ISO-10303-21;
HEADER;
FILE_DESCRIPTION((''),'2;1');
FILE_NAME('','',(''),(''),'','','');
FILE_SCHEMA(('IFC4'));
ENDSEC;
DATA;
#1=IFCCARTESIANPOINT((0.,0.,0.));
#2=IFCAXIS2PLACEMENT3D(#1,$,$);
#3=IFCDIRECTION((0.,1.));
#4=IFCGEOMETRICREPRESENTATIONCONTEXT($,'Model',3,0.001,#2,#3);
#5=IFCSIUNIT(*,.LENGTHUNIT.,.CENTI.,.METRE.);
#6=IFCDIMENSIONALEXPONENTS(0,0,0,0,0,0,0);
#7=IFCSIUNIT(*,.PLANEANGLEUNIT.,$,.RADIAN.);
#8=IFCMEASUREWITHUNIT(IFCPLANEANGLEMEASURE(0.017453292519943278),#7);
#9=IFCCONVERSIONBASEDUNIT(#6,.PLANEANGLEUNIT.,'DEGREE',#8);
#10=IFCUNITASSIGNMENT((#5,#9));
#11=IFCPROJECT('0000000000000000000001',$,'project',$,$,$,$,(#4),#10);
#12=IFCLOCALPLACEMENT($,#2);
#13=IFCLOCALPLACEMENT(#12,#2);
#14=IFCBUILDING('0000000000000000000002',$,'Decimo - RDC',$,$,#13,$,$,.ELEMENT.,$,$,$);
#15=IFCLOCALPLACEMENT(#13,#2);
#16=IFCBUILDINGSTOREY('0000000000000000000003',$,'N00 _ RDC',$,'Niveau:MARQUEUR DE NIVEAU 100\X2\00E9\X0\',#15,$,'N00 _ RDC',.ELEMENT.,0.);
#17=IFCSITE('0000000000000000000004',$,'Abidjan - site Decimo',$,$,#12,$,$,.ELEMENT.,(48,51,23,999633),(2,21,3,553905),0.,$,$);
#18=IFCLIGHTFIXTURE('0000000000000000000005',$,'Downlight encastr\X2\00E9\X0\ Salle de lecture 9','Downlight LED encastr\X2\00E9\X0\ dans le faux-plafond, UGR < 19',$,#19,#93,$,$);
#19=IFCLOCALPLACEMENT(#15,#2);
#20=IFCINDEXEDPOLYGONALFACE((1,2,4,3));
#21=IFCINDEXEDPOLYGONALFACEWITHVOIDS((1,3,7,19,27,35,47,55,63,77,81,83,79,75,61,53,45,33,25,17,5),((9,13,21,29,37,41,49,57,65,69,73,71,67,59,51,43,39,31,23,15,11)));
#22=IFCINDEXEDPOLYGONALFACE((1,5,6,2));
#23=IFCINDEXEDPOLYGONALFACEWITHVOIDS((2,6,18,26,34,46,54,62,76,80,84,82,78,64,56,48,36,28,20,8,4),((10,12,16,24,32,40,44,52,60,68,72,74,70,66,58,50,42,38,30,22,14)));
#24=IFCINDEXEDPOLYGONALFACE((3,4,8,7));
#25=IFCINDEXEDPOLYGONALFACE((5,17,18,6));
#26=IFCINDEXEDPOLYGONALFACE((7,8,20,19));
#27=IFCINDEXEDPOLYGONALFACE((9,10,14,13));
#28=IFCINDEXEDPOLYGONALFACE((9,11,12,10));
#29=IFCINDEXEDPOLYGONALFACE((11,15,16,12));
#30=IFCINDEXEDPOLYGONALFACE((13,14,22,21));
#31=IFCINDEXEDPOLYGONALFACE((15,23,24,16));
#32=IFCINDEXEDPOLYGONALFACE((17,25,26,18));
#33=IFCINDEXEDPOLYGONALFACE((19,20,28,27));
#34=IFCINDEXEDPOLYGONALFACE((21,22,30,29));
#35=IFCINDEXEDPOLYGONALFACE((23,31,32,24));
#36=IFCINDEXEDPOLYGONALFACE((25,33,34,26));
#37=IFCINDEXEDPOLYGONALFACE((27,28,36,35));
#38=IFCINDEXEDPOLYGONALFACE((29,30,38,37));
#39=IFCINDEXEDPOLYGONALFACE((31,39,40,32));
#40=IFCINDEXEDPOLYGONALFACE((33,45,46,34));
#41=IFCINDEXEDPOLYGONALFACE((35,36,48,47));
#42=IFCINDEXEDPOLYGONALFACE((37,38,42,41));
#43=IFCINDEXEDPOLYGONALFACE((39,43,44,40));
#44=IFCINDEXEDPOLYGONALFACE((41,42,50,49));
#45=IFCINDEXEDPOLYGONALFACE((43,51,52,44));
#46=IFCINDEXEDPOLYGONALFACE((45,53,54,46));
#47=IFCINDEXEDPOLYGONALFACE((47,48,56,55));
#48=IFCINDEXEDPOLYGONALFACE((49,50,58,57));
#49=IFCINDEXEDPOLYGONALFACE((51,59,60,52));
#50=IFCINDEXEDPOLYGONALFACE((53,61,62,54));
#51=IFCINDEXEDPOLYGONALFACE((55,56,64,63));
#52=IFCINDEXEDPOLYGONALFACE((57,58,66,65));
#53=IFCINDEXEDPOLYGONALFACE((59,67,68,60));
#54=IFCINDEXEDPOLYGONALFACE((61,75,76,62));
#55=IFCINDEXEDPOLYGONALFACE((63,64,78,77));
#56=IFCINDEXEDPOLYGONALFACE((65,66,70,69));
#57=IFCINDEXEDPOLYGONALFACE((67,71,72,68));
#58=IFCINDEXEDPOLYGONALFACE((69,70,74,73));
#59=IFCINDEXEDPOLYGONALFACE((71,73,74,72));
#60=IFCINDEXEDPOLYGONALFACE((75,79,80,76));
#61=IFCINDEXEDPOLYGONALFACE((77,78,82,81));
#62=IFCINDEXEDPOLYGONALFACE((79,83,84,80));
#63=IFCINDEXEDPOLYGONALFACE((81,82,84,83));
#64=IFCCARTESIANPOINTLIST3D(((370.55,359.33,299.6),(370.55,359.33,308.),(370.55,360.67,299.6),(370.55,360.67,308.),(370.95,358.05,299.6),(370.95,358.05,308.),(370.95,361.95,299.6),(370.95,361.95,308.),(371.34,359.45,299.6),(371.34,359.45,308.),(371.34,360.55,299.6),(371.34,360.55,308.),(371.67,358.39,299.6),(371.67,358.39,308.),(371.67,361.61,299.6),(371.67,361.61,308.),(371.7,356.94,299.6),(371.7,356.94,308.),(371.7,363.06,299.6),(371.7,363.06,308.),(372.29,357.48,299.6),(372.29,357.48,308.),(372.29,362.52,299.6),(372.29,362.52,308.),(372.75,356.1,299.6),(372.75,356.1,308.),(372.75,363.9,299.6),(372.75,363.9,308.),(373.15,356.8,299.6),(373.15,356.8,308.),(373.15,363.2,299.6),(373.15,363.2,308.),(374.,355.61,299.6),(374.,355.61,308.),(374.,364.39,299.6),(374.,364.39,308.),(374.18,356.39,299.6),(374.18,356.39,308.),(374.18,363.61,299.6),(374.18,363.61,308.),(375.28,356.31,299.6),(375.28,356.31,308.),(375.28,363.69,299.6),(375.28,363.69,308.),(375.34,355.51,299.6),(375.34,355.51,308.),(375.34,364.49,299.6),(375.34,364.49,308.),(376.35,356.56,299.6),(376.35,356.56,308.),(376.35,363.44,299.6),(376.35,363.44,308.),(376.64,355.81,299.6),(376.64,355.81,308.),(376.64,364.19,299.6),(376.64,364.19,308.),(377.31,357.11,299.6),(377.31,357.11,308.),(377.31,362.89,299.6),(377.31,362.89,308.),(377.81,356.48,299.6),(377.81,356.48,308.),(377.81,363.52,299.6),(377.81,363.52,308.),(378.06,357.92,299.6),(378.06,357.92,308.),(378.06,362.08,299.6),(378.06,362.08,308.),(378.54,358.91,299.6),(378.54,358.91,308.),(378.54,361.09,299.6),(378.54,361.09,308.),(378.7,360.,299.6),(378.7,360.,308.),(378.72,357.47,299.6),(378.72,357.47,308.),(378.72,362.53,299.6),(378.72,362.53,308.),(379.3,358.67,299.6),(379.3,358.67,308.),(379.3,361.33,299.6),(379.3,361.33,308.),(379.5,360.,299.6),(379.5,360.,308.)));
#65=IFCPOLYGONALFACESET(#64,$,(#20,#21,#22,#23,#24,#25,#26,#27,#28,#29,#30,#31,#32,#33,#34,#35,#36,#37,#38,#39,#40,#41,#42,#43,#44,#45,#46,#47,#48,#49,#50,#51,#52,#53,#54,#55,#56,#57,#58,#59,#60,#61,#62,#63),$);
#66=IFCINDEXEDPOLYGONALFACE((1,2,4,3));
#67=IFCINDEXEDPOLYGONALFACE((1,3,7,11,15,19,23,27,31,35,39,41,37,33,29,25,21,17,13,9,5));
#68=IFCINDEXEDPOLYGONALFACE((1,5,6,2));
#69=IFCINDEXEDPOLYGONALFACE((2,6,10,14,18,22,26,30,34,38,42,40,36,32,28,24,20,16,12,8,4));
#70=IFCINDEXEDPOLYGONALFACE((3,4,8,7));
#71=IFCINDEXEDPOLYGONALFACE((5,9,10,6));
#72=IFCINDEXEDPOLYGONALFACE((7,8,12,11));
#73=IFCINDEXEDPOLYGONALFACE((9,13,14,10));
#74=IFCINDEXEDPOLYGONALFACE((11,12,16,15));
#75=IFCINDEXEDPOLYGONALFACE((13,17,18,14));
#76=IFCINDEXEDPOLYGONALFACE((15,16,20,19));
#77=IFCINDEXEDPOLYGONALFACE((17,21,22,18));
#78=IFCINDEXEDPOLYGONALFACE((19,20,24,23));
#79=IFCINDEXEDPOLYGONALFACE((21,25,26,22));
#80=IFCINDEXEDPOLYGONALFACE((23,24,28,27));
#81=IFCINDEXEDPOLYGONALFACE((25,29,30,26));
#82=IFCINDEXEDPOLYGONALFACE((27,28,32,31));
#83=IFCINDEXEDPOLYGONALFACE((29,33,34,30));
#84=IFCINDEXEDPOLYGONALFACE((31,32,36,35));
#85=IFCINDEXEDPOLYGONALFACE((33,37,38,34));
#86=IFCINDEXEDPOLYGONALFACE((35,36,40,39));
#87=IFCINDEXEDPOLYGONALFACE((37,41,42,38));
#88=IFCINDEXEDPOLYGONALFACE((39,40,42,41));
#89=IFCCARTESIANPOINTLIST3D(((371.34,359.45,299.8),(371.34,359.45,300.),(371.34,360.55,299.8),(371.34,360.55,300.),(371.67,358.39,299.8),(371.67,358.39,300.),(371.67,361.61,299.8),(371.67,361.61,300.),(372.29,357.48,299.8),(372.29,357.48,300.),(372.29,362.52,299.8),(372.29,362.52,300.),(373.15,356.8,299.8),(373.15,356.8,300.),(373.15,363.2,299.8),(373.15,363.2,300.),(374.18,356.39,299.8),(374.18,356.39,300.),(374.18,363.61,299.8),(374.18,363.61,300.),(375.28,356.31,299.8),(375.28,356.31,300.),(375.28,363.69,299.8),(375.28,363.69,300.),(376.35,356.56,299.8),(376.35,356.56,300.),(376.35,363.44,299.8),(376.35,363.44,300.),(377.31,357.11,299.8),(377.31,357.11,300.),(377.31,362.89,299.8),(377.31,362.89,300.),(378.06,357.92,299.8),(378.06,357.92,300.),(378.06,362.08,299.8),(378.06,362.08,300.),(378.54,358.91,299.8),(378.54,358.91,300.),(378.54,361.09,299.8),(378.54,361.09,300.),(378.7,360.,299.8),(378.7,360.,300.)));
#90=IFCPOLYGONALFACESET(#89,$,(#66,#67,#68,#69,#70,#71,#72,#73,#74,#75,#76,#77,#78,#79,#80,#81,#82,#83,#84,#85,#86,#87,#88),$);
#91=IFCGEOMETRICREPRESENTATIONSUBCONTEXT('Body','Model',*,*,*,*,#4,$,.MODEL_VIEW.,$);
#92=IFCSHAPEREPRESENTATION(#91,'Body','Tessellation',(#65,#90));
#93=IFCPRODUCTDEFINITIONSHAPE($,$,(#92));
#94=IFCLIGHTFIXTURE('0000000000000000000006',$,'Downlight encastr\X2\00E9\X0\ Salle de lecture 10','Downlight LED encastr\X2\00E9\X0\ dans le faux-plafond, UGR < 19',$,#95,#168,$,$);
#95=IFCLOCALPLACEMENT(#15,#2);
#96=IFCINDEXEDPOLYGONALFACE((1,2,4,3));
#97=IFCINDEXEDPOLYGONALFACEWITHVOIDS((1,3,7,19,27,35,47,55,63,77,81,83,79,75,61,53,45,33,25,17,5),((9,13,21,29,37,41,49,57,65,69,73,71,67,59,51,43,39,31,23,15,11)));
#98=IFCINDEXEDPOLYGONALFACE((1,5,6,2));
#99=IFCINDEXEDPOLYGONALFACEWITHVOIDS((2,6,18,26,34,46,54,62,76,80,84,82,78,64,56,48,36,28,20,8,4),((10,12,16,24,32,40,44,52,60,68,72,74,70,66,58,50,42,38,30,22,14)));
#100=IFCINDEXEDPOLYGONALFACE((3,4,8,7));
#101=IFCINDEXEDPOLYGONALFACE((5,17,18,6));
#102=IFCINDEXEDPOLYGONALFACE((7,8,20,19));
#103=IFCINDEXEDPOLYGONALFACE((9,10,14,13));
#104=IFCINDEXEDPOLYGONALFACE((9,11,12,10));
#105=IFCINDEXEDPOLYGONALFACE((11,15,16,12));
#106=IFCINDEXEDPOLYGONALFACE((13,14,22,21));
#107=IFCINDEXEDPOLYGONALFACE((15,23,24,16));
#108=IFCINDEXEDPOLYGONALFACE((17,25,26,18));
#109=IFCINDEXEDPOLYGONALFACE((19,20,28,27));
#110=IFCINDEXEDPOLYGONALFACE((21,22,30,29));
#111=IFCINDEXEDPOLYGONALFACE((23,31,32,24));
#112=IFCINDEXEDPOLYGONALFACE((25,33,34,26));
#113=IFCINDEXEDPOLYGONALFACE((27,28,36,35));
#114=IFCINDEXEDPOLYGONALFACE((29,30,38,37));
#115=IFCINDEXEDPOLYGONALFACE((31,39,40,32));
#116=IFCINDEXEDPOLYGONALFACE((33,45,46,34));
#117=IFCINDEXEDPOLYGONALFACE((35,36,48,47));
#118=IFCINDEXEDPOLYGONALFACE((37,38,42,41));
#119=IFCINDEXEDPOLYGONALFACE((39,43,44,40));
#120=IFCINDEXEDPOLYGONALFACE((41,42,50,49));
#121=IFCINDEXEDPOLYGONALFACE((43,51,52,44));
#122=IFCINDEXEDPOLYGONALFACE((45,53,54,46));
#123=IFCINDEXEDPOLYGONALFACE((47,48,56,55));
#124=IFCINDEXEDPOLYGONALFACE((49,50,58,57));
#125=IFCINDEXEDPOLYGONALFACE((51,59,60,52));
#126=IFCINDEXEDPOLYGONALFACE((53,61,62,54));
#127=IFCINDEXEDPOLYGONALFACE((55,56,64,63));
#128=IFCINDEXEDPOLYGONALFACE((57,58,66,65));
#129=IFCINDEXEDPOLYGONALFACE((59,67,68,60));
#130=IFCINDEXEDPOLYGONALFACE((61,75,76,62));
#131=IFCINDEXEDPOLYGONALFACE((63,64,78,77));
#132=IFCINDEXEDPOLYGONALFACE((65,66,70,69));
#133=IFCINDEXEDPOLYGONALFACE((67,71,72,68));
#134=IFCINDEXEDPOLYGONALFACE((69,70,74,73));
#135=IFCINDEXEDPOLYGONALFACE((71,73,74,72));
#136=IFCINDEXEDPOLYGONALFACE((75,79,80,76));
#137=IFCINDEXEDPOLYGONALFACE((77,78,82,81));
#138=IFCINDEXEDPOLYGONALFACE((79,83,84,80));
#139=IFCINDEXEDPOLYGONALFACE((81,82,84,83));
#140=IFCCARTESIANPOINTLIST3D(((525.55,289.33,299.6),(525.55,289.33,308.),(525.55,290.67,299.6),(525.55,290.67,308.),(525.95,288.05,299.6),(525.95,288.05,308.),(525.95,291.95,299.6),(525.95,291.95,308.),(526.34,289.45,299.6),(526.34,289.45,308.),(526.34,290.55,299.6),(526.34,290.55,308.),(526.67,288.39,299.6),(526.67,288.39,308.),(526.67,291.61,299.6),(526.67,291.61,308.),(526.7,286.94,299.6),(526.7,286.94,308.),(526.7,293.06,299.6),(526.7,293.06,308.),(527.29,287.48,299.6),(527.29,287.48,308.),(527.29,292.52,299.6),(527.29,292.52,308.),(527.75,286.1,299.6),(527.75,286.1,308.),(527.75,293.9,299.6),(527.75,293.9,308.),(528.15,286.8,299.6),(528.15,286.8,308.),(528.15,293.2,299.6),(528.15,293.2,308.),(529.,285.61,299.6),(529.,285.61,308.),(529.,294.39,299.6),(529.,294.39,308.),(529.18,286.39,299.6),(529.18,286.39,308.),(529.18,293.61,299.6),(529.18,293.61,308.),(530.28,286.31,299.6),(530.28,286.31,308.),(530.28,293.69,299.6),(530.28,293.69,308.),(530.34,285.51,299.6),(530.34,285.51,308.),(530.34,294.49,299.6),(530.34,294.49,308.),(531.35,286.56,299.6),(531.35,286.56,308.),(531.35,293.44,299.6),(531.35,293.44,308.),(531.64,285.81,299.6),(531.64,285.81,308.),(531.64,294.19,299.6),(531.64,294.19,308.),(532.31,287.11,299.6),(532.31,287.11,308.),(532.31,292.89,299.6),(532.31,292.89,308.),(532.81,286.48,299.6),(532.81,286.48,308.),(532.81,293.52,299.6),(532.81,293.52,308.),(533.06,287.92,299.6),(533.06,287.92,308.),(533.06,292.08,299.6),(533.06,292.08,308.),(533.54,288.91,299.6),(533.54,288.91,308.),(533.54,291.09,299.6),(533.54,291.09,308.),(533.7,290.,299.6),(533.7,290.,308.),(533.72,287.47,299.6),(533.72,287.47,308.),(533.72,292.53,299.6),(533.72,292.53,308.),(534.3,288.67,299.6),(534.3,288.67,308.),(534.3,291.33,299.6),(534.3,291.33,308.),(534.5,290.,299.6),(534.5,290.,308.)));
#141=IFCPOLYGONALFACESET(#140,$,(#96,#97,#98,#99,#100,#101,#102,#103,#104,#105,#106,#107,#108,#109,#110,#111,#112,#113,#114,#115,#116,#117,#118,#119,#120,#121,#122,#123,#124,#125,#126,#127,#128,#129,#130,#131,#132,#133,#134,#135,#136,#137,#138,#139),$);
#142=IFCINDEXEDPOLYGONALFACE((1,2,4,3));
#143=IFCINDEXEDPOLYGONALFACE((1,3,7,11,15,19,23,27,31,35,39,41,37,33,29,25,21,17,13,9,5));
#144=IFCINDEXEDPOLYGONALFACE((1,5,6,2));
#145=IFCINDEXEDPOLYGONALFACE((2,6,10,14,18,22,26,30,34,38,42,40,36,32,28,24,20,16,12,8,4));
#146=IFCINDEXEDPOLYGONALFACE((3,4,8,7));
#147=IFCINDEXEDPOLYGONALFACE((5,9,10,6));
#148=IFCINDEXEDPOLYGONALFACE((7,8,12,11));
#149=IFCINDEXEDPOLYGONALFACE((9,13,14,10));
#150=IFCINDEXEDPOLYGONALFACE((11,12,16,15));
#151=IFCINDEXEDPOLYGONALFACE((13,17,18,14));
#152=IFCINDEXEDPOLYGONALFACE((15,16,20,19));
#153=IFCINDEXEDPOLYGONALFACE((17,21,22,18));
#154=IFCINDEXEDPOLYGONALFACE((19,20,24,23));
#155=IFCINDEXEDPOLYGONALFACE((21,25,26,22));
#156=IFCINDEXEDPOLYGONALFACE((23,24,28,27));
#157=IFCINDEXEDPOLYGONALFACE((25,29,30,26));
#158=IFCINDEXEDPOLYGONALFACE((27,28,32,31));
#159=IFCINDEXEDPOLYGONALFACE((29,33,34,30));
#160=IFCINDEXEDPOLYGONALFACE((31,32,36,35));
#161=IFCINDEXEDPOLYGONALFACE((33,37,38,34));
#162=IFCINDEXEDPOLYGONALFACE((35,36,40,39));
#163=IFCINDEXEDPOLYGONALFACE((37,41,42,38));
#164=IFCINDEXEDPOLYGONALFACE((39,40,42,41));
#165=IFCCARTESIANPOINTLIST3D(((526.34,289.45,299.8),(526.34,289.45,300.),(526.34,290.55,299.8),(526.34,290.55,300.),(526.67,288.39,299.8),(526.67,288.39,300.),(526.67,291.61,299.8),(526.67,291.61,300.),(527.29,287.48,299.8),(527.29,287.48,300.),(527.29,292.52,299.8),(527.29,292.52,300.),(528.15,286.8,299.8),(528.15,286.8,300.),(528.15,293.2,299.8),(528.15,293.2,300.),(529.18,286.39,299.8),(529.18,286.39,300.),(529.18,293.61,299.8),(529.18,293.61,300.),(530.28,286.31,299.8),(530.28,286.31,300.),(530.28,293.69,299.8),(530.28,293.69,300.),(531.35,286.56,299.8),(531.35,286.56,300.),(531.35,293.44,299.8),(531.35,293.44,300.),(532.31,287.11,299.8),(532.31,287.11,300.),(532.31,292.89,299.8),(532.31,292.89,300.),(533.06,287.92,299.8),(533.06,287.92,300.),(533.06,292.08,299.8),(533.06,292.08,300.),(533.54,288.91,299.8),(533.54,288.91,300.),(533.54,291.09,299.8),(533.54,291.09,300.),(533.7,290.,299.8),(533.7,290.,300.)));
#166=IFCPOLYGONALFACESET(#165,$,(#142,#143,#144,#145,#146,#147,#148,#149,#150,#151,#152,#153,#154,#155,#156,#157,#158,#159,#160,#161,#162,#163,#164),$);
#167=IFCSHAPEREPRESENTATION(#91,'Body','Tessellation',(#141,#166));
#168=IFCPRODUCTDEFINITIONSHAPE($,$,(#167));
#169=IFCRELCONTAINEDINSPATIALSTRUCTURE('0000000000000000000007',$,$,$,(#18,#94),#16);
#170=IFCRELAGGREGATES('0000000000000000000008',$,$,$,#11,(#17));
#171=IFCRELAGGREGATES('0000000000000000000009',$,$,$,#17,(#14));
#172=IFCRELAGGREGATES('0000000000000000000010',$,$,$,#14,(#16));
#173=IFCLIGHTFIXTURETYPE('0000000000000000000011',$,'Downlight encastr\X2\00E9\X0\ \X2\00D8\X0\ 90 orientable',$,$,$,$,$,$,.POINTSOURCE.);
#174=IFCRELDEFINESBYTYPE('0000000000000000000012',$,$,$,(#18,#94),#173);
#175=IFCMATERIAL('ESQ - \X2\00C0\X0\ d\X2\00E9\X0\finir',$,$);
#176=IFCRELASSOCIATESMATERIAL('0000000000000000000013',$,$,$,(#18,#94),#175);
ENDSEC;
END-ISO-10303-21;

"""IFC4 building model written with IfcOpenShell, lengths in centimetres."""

from ifc_helpers import new_model, entity, si_unit, converted_unit, direction, frame, frame_2d, origin, origin_with_axes, place, context, subcontext, project, spatial, circle, hollow_circle, extrude, material, type_object, element, save


model = new_model("IFC4")

# Units and contexts
model_context = context("Model", 3, precision=0.001, world=origin(), true_north=direction((0.0, 1.0)))
body_context = subcontext(model_context, "Body", "Model", "MODEL_VIEW")
ifc_project = project(units=[si_unit("LENGTHUNIT", "METRE", prefix="CENTI"), converted_unit("PLANEANGLEUNIT", "DEGREE", entity("IfcPlaneAngleMeasure", 0.017453292519943278), si_unit("PLANEANGLEUNIT", "RADIAN"), dimensions=[0, 0, 0, 0, 0, 0, 0])], contexts=[model_context])

# Site, building, storey
site_placement = place(None, origin())
site = spatial("IfcSite", under=ifc_project, at=site_placement, Name="Abidjan - site Decimo", CompositionType="ELEMENT", RefLatitude=(48, 51, 23, 999633), RefLongitude=(2, 21, 3, 553905), RefElevation=0.0)
building_placement = place(site_placement, origin())
building = spatial("IfcBuilding", under=site, at=building_placement, Name="Decimo - RDC", CompositionType="ELEMENT")
storey_placement = place(building_placement, origin())
storey = spatial("IfcBuildingStorey", under=building, at=storey_placement, Name="N00 _ RDC", ObjectType="Niveau:MARQUEUR DE NIVEAU 100é", LongName="N00 _ RDC", CompositionType="ELEMENT", Elevation=0.0)

# Light fixtures
ifc_material_1 = material(Name="ESQ - À définir")
light_fixture_type_1 = type_object("IfcLightFixtureType", Name="Downlight encastré Ø 90 orientable", PredefinedType="POINTSOURCE")
light_fixture_1_placement = place(storey_placement, origin_with_axes())
element("IfcLightFixture", 1, at=light_fixture_1_placement, inside=storey, type_object=light_fixture_type_1, material=ifc_material_1, Name="Downlight encastré Salle de lecture 9", Description="Downlight LED encastré dans le faux-plafond, UGR < 19", context=body_context, shape_type="SweptSolid", body=[
    extrude(hollow_circle(Radius=4.5, WallThickness=0.8, at=frame_2d((375.0, 360.0))), frame((0.0, 0.0, 299.6)), (0.0, 0.0, 1.0), 8.4),
    extrude(circle(Radius=3.7, at=frame_2d((375.0, 360.0))), frame((0.0, 0.0, 299.8)), (0.0, 0.0, 1.0), 0.2),
])
light_fixture_2_placement = place(storey_placement, origin_with_axes())
element("IfcLightFixture", 2, at=light_fixture_2_placement, inside=storey, type_object=light_fixture_type_1, material=ifc_material_1, Name="Downlight encastré Salle de lecture 10", Description="Downlight LED encastré dans le faux-plafond, UGR < 19", context=body_context, shape_type="SweptSolid", body=[
    extrude(hollow_circle(Radius=4.5, WallThickness=0.8, at=frame_2d((530.0, 290.0))), frame((0.0, 0.0, 299.6)), (0.0, 0.0, 1.0), 8.4),
    extrude(circle(Radius=3.7, at=frame_2d((530.0, 290.0))), frame((0.0, 0.0, 299.8)), (0.0, 0.0, 1.0), 0.2),
])

save(model, "model.ifc")
